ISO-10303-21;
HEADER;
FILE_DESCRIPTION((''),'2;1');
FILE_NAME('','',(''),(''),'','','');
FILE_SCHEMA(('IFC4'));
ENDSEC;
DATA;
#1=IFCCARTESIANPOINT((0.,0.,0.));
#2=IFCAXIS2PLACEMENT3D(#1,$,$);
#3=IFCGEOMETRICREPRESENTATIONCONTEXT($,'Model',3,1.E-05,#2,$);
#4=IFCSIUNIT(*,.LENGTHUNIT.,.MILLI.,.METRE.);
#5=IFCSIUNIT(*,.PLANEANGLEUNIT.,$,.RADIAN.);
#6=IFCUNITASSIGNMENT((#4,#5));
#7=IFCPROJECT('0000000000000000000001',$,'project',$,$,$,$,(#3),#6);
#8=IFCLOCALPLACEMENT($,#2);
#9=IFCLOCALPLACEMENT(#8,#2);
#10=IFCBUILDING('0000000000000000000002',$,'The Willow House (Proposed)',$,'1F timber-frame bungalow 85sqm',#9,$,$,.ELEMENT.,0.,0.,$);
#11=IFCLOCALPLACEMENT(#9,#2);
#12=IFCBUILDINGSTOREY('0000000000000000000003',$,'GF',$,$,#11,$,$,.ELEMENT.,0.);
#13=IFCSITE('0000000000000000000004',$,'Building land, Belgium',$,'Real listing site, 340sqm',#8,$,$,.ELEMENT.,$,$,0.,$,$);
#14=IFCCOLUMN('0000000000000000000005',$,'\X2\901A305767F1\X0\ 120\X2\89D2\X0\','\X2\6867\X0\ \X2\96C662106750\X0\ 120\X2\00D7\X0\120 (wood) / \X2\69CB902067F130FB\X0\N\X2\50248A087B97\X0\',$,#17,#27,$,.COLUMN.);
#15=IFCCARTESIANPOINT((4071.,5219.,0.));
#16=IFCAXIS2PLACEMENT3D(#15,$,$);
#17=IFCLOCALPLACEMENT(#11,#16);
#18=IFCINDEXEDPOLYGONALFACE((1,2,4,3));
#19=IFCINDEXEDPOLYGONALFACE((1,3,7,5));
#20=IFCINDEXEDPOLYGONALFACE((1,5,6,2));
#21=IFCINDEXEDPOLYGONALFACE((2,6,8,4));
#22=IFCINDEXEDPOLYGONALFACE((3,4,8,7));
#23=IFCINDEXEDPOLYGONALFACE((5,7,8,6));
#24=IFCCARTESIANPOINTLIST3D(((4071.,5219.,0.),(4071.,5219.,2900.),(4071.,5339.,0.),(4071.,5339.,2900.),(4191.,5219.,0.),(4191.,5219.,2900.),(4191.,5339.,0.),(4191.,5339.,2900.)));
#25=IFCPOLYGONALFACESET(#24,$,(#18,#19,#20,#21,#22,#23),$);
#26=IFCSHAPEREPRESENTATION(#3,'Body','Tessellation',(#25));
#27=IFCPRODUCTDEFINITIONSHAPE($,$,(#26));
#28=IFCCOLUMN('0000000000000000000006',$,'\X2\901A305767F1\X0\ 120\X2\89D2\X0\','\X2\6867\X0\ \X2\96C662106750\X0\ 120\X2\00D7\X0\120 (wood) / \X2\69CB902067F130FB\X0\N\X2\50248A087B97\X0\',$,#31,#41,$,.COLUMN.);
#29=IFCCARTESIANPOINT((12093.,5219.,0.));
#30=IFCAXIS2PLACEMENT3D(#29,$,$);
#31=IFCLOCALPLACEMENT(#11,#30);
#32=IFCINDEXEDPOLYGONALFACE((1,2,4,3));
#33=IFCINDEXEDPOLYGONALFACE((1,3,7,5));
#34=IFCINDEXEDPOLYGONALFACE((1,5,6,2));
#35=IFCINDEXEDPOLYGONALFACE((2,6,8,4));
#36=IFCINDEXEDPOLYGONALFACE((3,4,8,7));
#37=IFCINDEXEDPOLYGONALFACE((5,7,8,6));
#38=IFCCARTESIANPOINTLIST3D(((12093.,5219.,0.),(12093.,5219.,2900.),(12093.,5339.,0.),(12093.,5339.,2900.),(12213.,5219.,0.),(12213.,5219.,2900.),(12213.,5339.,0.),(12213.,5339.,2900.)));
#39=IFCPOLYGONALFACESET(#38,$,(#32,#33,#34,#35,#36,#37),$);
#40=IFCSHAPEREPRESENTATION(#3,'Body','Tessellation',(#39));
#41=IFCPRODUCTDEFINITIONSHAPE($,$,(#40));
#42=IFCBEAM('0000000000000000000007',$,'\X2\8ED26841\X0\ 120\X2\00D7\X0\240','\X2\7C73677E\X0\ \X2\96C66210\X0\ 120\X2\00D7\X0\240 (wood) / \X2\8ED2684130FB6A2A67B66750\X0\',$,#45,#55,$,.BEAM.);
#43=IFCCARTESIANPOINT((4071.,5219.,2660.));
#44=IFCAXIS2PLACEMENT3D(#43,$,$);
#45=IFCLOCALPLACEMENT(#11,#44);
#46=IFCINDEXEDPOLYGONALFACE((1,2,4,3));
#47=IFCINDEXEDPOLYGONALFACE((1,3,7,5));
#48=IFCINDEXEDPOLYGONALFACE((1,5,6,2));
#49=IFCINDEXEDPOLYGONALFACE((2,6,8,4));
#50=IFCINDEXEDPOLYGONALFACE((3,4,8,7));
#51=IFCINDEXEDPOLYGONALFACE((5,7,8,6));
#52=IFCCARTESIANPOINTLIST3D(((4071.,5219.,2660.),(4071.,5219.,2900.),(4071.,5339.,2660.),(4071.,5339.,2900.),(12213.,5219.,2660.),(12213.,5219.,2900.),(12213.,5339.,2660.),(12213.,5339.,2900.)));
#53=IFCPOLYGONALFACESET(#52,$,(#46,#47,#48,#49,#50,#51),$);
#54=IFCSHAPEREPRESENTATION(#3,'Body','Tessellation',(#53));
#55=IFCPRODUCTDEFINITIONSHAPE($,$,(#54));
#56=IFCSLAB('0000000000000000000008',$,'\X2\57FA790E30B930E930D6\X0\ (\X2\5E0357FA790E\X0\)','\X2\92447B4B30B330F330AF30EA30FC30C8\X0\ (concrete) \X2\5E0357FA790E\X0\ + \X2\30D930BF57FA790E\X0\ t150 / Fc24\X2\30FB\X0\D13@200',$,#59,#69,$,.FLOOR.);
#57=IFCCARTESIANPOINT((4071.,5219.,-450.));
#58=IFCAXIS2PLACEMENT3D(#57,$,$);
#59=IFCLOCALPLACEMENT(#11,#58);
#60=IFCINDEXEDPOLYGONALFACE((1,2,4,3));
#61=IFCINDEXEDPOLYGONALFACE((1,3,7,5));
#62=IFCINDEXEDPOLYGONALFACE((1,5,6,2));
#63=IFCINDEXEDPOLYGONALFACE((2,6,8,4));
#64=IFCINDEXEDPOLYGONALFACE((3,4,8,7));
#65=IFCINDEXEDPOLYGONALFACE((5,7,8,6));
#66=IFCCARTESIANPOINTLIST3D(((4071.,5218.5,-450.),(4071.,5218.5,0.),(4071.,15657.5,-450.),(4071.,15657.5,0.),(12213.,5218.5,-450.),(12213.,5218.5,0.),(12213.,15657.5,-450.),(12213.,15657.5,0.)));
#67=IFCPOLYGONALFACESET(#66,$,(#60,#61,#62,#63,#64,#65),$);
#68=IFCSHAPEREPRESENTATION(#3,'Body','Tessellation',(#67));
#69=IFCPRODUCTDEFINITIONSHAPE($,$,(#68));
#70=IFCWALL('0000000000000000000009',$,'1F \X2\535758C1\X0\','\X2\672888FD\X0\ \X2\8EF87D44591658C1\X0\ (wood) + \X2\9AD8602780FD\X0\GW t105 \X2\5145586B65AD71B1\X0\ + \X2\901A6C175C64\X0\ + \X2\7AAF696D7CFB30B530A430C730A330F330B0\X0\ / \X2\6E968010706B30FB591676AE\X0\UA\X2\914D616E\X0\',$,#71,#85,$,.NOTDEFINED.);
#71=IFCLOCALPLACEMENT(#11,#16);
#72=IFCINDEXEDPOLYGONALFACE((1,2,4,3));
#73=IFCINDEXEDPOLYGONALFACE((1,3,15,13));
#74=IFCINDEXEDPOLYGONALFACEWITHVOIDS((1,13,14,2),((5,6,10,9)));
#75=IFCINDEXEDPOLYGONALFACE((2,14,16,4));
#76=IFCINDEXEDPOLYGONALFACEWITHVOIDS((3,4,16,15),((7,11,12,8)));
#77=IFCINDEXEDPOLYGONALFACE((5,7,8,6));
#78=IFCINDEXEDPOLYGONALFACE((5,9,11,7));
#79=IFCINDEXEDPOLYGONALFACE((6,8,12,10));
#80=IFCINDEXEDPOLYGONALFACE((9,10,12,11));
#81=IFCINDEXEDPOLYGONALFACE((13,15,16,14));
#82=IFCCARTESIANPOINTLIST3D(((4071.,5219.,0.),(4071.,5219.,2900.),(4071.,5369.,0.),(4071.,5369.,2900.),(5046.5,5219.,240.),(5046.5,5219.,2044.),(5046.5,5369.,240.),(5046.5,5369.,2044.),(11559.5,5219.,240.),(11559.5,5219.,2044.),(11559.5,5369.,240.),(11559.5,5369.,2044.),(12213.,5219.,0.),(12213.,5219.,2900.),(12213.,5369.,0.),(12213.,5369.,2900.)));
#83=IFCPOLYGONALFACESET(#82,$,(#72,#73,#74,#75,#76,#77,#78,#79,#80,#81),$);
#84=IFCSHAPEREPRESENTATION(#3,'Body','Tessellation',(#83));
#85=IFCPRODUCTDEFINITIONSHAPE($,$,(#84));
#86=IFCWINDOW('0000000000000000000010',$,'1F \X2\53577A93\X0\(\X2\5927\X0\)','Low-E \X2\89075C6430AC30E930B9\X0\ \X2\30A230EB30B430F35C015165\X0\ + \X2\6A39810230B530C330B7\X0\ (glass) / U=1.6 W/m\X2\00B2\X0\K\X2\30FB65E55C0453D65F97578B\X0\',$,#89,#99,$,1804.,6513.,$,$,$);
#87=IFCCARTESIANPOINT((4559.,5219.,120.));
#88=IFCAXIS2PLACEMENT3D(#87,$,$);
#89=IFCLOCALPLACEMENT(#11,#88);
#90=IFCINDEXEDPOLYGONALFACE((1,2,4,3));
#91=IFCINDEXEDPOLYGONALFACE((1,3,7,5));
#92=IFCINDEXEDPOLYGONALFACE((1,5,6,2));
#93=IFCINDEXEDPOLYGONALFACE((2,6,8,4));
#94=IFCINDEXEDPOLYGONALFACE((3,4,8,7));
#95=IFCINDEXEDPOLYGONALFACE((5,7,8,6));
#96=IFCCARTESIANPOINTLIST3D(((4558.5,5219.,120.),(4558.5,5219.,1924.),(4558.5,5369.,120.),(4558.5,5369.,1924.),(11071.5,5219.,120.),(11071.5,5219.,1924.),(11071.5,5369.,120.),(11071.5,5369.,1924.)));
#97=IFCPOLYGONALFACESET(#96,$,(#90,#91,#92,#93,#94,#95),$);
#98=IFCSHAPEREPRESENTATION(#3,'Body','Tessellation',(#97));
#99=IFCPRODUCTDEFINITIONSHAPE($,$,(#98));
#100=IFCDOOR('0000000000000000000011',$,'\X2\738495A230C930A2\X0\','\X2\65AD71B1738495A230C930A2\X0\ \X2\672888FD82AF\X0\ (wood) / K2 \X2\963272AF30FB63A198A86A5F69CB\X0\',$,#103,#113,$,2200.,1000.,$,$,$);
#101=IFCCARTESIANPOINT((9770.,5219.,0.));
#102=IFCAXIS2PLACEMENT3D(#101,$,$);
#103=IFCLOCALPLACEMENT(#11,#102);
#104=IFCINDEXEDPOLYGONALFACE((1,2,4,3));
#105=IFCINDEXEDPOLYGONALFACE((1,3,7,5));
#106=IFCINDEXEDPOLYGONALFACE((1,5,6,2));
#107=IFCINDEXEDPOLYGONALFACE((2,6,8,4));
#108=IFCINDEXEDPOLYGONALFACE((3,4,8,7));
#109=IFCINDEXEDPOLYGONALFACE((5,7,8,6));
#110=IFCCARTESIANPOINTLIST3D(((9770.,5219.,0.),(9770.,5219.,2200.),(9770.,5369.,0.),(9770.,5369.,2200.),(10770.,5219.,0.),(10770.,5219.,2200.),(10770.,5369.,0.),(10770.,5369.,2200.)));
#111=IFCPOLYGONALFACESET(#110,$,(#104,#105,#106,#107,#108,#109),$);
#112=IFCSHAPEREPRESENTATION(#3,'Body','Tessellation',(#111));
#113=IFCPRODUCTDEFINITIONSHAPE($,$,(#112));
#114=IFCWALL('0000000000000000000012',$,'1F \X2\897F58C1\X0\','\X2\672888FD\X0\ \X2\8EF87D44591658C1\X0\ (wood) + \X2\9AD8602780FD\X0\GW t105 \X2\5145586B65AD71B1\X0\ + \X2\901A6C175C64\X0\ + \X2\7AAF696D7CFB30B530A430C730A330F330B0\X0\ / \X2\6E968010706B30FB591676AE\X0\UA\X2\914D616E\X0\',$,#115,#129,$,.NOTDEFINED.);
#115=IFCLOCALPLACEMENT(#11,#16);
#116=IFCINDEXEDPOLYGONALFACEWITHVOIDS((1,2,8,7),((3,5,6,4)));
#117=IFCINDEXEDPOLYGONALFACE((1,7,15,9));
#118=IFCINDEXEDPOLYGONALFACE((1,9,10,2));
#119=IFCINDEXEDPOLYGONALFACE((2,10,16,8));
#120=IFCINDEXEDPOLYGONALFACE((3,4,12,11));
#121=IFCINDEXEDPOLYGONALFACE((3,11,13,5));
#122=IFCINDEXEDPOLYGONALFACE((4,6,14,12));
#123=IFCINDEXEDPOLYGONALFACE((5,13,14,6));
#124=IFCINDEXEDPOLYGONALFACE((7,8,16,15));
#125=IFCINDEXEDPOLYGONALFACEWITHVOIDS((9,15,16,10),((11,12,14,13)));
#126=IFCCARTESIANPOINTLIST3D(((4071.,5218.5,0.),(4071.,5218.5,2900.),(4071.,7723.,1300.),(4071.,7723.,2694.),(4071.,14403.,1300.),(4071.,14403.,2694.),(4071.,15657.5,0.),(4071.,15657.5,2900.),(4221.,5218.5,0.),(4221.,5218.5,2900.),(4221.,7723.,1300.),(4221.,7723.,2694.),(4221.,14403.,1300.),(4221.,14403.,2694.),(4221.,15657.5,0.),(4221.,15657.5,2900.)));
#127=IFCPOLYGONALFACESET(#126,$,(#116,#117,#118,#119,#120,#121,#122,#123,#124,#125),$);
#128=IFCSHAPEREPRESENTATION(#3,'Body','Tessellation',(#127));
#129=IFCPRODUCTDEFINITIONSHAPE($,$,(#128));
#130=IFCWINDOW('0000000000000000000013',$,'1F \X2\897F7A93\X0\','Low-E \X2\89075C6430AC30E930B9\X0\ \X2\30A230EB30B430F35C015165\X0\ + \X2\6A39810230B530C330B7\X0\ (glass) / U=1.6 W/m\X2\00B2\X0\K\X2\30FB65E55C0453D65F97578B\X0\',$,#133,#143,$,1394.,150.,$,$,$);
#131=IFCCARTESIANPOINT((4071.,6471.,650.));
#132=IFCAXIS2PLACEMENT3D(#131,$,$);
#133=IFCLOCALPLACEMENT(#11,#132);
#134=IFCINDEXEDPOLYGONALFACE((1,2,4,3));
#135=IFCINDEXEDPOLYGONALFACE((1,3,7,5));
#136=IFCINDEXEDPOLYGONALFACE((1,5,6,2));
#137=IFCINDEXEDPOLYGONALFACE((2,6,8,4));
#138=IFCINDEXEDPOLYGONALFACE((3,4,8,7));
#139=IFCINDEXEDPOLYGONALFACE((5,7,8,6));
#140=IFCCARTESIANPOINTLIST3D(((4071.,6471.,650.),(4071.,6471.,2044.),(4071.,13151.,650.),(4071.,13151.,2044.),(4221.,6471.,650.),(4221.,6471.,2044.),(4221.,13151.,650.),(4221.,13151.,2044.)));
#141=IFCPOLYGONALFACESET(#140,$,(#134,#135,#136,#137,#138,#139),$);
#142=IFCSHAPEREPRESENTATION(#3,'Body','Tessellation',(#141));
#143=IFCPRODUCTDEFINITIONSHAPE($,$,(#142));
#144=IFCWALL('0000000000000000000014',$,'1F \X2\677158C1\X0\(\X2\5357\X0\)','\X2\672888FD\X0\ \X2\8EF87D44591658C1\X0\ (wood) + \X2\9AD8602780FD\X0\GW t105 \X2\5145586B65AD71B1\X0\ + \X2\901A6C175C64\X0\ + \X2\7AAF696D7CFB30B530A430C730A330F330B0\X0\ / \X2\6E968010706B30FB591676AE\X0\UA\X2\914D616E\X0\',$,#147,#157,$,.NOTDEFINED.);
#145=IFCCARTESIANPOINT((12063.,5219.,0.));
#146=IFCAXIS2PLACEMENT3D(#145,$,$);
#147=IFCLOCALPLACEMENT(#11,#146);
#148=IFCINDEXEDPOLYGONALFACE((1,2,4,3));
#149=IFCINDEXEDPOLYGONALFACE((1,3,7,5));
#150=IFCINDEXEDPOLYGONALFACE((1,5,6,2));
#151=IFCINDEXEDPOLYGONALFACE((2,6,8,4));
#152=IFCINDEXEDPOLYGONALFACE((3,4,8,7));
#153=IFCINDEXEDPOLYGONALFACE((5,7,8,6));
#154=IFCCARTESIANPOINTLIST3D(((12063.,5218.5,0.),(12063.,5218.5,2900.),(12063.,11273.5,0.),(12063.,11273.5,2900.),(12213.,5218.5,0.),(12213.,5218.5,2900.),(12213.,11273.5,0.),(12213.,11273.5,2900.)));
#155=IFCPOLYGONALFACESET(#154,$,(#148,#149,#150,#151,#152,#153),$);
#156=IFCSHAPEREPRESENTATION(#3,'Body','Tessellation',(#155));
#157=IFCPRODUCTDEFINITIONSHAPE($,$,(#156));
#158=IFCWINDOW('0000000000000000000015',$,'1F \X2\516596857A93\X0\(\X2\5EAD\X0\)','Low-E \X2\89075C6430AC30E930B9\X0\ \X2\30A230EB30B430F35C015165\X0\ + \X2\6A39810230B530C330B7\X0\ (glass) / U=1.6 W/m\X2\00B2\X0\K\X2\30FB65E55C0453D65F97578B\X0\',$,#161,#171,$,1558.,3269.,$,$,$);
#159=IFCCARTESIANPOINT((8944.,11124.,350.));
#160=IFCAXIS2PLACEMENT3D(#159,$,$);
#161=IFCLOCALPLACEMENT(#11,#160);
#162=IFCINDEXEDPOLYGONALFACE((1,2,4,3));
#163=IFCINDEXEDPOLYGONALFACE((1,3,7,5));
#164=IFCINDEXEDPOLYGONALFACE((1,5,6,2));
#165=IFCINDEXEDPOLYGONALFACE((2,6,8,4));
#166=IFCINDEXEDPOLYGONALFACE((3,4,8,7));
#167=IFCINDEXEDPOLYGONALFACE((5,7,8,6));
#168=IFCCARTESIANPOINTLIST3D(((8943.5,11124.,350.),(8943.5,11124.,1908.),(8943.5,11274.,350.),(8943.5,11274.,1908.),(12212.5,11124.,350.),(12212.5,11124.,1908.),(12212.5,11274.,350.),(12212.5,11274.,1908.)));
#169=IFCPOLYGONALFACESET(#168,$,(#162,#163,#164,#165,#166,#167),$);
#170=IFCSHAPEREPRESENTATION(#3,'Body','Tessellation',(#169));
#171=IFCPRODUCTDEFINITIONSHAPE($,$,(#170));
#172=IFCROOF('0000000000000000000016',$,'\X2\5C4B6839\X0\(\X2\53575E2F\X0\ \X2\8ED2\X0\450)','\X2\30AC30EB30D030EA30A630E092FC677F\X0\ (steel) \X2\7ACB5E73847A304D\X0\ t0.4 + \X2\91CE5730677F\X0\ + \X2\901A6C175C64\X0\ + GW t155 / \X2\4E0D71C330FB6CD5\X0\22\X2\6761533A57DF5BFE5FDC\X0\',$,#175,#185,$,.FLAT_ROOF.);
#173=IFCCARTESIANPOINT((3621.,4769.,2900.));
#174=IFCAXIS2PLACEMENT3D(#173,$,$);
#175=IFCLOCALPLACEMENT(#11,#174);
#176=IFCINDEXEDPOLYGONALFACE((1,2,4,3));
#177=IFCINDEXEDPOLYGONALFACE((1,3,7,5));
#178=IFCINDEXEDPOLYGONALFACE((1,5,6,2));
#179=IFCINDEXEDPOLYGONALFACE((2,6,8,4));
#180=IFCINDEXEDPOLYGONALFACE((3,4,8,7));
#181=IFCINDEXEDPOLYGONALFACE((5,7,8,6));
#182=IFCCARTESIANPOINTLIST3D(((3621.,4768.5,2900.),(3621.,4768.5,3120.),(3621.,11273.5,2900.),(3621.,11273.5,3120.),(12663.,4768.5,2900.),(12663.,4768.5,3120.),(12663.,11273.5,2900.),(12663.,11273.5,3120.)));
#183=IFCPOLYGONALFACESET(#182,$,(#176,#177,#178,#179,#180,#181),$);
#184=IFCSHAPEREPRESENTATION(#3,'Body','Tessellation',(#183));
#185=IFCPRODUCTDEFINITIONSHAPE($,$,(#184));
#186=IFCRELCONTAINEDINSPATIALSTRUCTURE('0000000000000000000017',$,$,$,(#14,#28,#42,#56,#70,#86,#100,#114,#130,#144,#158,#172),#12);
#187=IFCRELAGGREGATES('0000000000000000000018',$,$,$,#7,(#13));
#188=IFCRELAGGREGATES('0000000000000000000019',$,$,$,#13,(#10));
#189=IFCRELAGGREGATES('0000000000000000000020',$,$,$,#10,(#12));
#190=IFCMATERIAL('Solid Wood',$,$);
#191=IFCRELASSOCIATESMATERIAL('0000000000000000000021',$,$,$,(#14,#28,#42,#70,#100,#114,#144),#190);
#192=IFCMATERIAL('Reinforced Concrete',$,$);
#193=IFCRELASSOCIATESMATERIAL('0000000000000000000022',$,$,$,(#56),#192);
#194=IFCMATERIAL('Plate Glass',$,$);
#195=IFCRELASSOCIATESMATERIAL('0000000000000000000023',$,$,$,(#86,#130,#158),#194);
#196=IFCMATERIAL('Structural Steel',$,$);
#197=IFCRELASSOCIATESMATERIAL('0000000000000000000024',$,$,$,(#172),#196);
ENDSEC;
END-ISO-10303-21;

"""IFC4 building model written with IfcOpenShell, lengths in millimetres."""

from ifc_helpers import new_model, si_unit, frame, frame_2d, origin, place, context, project, spatial, rectangle, extrude, material, element, fill, save


model = new_model("IFC4")

# Units and contexts
model_context = context("Model", 3, precision=1e-05, world=origin())
ifc_project = project(units=[si_unit("LENGTHUNIT", "METRE", prefix="MILLI"), si_unit("PLANEANGLEUNIT", "RADIAN")], contexts=[model_context])

# Site, building, storey
site_placement = place(None, origin())
site = spatial("IfcSite", under=ifc_project, at=site_placement, Name="Building land, Belgium", ObjectType="Real listing site, 340sqm", CompositionType="ELEMENT", RefElevation=0.0)
building_placement = place(site_placement, origin())
building = spatial("IfcBuilding", under=site, at=building_placement, Name="The Willow House (Proposed)", ObjectType="1F timber-frame bungalow 85sqm", CompositionType="ELEMENT", ElevationOfRefHeight=0.0, ElevationOfTerrain=0.0)
storey_placement = place(building_placement, origin())
storey = spatial("IfcBuildingStorey", under=building, at=storey_placement, Name="GF", CompositionType="ELEMENT", Elevation=0.0)

# Columns
ifc_material_1 = material(Name="Solid Wood")
column_1_placement = place(storey_placement, frame((4071.0, 5219.0, 0.0)))
element("IfcColumn", 1, at=column_1_placement, inside=storey, material=ifc_material_1, Name="通し柱 120角", Description="桧 集成材 120×120 (wood) / 構造柱・N値計算", PredefinedType="COLUMN", context=model_context, shape_type="SweptSolid", body=[
    extrude(rectangle(XDim=120.0, YDim=120.0, at=frame_2d((60.0, 60.0))), frame((4071.0, 5219.0, 0.0)), (0.0, 0.0, 1.0), 2900.0),
])
column_2_placement = place(storey_placement, frame((12093.0, 5219.0, 0.0)))
element("IfcColumn", 2, at=column_2_placement, inside=storey, material=ifc_material_1, Name="通し柱 120角", Description="桧 集成材 120×120 (wood) / 構造柱・N値計算", PredefinedType="COLUMN", context=model_context, shape_type="SweptSolid", body=[
    extrude(rectangle(XDim=120.0, YDim=120.0, at=frame_2d((60.0, 60.0))), frame((12093.0, 5219.0, 0.0)), (0.0, 0.0, 1.0), 2900.0),
])

# Beam
beam_1_placement = place(storey_placement, frame((4071.0, 5219.0, 2660.0)))
element("IfcBeam", 3, at=beam_1_placement, inside=storey, material=ifc_material_1, Name="軒桁 120×240", Description="米松 集成 120×240 (wood) / 軒桁・横架材", PredefinedType="BEAM", context=model_context, shape_type="SweptSolid", body=[
    extrude(rectangle(XDim=8142.0, YDim=120.0, at=frame_2d((4071.0, 60.0))), frame((4071.0, 5219.0, 2660.0)), (0.0, 0.0, 1.0), 240.0),
])

# Slab
ifc_material_2 = material(Name="Reinforced Concrete")
slab_1_placement = place(storey_placement, frame((4071.0, 5219.0, -450.0)))
element("IfcSlab", 4, at=slab_1_placement, inside=storey, material=ifc_material_2, Name="基礎スラブ (布基礎)", Description="鉄筋コンクリート (concrete) 布基礎 + ベタ基礎 t150 / Fc24・D13@200", PredefinedType="FLOOR", context=model_context, shape_type="SweptSolid", body=[
    extrude(rectangle(XDim=8142.0, YDim=10439.0, at=frame_2d((4071.0, 5219.0))), frame((4071.0, 5219.0, -450.0)), (0.0, 0.0, 1.0), 450.0),
])

# Wall, openings, window, door
wall_1_placement = place(storey_placement, frame((4071.0, 5219.0, 0.0)))
wall_1 = element("IfcWall", 5, at=wall_1_placement, inside=storey, material=ifc_material_1, Name="1F 南壁", Description="木製 軸組外壁 (wood) + 高性能GW t105 充填断熱 + 通気層 + 窯業系サイディング / 準耐火・外皮UA配慮", PredefinedType="NOTDEFINED", context=model_context, shape_type="SweptSolid", body=[
    extrude(rectangle(XDim=8142.0, YDim=150.0, at=frame_2d((4071.0, 75.0))), frame((4071.0, 5219.0, 0.0)), (0.0, 0.0, 1.0), 2900.0),
])
opening_1_placement = place(storey_placement, frame((4559.0, 5219.0, 120.0)))
opening_1 = element("IfcOpeningElement", 6, at=opening_1_placement, cuts=wall_1, PredefinedType="NOTDEFINED", context=model_context, shape_type="SweptSolid", body=[
    extrude(rectangle(XDim=6513.0, YDim=150.0, at=frame_2d((3256.0, 75.0))), frame((4559.0, 5219.0, 120.0)), (0.0, 0.0, 1.0), 1804.0),
])
opening_2_placement = place(storey_placement, frame((9770.0, 5219.0, 0.0)))
opening_2 = element("IfcOpeningElement", 7, at=opening_2_placement, cuts=wall_1, PredefinedType="NOTDEFINED", context=model_context, shape_type="SweptSolid", body=[
    extrude(rectangle(XDim=1000.0, YDim=150.0, at=frame_2d((500.0, 75.0))), frame((9770.0, 5219.0, 0.0)), (0.0, 0.0, 1.0), 2200.0),
])
ifc_material_3 = material(Name="Plate Glass")
window_1_placement = place(storey_placement, frame((4559.0, 5219.0, 120.0)))
window_1 = element("IfcWindow", 8, at=window_1_placement, inside=storey, material=ifc_material_3, Name="1F 南窓(大)", Description="Low-E 複層ガラス アルゴン封入 + 樹脂サッシ (glass) / U=1.6 W/m²K・日射取得型", OverallHeight=1804.0, OverallWidth=6513.0, context=model_context, shape_type="SweptSolid", body=[
    extrude(rectangle(XDim=6513.0, YDim=150.0, at=frame_2d((3256.0, 75.0))), frame((4559.0, 5219.0, 120.0)), (0.0, 0.0, 1.0), 1804.0),
])
fill(opening_1, window_1)
door_1_placement = place(storey_placement, frame((9770.0, 5219.0, 0.0)))
door_1 = element("IfcDoor", 9, at=door_1_placement, inside=storey, material=ifc_material_1, Name="玄関ドア", Description="断熱玄関ドア 木製芯 (wood) / K2 防犯・採風機構", OverallHeight=2200.0, OverallWidth=1000.0, context=model_context, shape_type="SweptSolid", body=[
    extrude(rectangle(XDim=1000.0, YDim=150.0, at=frame_2d((500.0, 75.0))), frame((9770.0, 5219.0, 0.0)), (0.0, 0.0, 1.0), 2200.0),
])
fill(opening_2, door_1)

# Walls, openings, windows
wall_2_placement = place(storey_placement, frame((4071.0, 5219.0, 0.0)))
wall_2 = element("IfcWall", 10, at=wall_2_placement, inside=storey, material=ifc_material_1, Name="1F 西壁", Description="木製 軸組外壁 (wood) + 高性能GW t105 充填断熱 + 通気層 + 窯業系サイディング / 準耐火・外皮UA配慮", PredefinedType="NOTDEFINED", context=model_context, shape_type="SweptSolid", body=[
    extrude(rectangle(XDim=150.0, YDim=10439.0, at=frame_2d((75.0, 5219.0))), frame((4071.0, 5219.0, 0.0)), (0.0, 0.0, 1.0), 2900.0),
])
opening_3_placement = place(storey_placement, frame((4071.0, 6471.0, 650.0)))
opening_3 = element("IfcOpeningElement", 11, at=opening_3_placement, cuts=wall_2, PredefinedType="NOTDEFINED", context=model_context, shape_type="SweptSolid", body=[
    extrude(rectangle(XDim=150.0, YDim=6680.0, at=frame_2d((75.0, 3340.0))), frame((4071.0, 6471.0, 650.0)), (0.0, 0.0, 1.0), 1394.0),
])
window_2_placement = place(storey_placement, frame((4071.0, 6471.0, 650.0)))
window_2 = element("IfcWindow", 12, at=window_2_placement, inside=storey, material=ifc_material_3, Name="1F 西窓", Description="Low-E 複層ガラス アルゴン封入 + 樹脂サッシ (glass) / U=1.6 W/m²K・日射取得型", OverallHeight=1394.0, OverallWidth=150.0, context=model_context, shape_type="SweptSolid", body=[
    extrude(rectangle(XDim=150.0, YDim=6680.0, at=frame_2d((75.0, 3340.0))), frame((4071.0, 6471.0, 650.0)), (0.0, 0.0, 1.0), 1394.0),
])
fill(opening_3, window_2)
wall_3_placement = place(storey_placement, frame((12063.0, 5219.0, 0.0)))
wall_3 = element("IfcWall", 13, at=wall_3_placement, inside=storey, material=ifc_material_1, Name="1F 東壁(南)", Description="木製 軸組外壁 (wood) + 高性能GW t105 充填断熱 + 通気層 + 窯業系サイディング / 準耐火・外皮UA配慮", PredefinedType="NOTDEFINED", context=model_context, shape_type="SweptSolid", body=[
    extrude(rectangle(XDim=150.0, YDim=6055.0, at=frame_2d((75.0, 3027.0))), frame((12063.0, 5219.0, 0.0)), (0.0, 0.0, 1.0), 2900.0),
])
opening_4_placement = place(storey_placement, frame((8944.0, 11124.0, 350.0)))
opening_4 = element("IfcOpeningElement", 14, at=opening_4_placement, cuts=wall_3, PredefinedType="NOTDEFINED", context=model_context, shape_type="SweptSolid", body=[
    extrude(rectangle(XDim=3269.0, YDim=150.0, at=frame_2d((1634.0, 75.0))), frame((8944.0, 11124.0, 350.0)), (0.0, 0.0, 1.0), 1558.0),
])
window_3_placement = place(storey_placement, frame((8944.0, 11124.0, 350.0)))
window_3 = element("IfcWindow", 15, at=window_3_placement, inside=storey, material=ifc_material_3, Name="1F 入隅窓(庭)", Description="Low-E 複層ガラス アルゴン封入 + 樹脂サッシ (glass) / U=1.6 W/m²K・日射取得型", OverallHeight=1558.0, OverallWidth=3269.0, context=model_context, shape_type="SweptSolid", body=[
    extrude(rectangle(XDim=3269.0, YDim=150.0, at=frame_2d((1634.0, 75.0))), frame((8944.0, 11124.0, 350.0)), (0.0, 0.0, 1.0), 1558.0),
])
fill(opening_4, window_3)

# Roof
ifc_material_4 = material(Name="Structural Steel")
roof_placement = place(storey_placement, frame((3621.0, 4769.0, 2900.0)))
element("IfcRoof", 16, at=roof_placement, inside=storey, material=ifc_material_4, Name="屋根(南帯 軒450)", Description="ガルバリウム鋼板 (steel) 立平葺き t0.4 + 野地板 + 通気層 + GW t155 / 不燃・法22条区域対応", PredefinedType="FLAT_ROOF", context=model_context, shape_type="SweptSolid", body=[
    extrude(rectangle(XDim=9042.0, YDim=6505.0, at=frame_2d((4521.0, 3252.0))), frame((3621.0, 4769.0, 2900.0)), (0.0, 0.0, 1.0), 220.0),
])

save(model, "model.ifc")
